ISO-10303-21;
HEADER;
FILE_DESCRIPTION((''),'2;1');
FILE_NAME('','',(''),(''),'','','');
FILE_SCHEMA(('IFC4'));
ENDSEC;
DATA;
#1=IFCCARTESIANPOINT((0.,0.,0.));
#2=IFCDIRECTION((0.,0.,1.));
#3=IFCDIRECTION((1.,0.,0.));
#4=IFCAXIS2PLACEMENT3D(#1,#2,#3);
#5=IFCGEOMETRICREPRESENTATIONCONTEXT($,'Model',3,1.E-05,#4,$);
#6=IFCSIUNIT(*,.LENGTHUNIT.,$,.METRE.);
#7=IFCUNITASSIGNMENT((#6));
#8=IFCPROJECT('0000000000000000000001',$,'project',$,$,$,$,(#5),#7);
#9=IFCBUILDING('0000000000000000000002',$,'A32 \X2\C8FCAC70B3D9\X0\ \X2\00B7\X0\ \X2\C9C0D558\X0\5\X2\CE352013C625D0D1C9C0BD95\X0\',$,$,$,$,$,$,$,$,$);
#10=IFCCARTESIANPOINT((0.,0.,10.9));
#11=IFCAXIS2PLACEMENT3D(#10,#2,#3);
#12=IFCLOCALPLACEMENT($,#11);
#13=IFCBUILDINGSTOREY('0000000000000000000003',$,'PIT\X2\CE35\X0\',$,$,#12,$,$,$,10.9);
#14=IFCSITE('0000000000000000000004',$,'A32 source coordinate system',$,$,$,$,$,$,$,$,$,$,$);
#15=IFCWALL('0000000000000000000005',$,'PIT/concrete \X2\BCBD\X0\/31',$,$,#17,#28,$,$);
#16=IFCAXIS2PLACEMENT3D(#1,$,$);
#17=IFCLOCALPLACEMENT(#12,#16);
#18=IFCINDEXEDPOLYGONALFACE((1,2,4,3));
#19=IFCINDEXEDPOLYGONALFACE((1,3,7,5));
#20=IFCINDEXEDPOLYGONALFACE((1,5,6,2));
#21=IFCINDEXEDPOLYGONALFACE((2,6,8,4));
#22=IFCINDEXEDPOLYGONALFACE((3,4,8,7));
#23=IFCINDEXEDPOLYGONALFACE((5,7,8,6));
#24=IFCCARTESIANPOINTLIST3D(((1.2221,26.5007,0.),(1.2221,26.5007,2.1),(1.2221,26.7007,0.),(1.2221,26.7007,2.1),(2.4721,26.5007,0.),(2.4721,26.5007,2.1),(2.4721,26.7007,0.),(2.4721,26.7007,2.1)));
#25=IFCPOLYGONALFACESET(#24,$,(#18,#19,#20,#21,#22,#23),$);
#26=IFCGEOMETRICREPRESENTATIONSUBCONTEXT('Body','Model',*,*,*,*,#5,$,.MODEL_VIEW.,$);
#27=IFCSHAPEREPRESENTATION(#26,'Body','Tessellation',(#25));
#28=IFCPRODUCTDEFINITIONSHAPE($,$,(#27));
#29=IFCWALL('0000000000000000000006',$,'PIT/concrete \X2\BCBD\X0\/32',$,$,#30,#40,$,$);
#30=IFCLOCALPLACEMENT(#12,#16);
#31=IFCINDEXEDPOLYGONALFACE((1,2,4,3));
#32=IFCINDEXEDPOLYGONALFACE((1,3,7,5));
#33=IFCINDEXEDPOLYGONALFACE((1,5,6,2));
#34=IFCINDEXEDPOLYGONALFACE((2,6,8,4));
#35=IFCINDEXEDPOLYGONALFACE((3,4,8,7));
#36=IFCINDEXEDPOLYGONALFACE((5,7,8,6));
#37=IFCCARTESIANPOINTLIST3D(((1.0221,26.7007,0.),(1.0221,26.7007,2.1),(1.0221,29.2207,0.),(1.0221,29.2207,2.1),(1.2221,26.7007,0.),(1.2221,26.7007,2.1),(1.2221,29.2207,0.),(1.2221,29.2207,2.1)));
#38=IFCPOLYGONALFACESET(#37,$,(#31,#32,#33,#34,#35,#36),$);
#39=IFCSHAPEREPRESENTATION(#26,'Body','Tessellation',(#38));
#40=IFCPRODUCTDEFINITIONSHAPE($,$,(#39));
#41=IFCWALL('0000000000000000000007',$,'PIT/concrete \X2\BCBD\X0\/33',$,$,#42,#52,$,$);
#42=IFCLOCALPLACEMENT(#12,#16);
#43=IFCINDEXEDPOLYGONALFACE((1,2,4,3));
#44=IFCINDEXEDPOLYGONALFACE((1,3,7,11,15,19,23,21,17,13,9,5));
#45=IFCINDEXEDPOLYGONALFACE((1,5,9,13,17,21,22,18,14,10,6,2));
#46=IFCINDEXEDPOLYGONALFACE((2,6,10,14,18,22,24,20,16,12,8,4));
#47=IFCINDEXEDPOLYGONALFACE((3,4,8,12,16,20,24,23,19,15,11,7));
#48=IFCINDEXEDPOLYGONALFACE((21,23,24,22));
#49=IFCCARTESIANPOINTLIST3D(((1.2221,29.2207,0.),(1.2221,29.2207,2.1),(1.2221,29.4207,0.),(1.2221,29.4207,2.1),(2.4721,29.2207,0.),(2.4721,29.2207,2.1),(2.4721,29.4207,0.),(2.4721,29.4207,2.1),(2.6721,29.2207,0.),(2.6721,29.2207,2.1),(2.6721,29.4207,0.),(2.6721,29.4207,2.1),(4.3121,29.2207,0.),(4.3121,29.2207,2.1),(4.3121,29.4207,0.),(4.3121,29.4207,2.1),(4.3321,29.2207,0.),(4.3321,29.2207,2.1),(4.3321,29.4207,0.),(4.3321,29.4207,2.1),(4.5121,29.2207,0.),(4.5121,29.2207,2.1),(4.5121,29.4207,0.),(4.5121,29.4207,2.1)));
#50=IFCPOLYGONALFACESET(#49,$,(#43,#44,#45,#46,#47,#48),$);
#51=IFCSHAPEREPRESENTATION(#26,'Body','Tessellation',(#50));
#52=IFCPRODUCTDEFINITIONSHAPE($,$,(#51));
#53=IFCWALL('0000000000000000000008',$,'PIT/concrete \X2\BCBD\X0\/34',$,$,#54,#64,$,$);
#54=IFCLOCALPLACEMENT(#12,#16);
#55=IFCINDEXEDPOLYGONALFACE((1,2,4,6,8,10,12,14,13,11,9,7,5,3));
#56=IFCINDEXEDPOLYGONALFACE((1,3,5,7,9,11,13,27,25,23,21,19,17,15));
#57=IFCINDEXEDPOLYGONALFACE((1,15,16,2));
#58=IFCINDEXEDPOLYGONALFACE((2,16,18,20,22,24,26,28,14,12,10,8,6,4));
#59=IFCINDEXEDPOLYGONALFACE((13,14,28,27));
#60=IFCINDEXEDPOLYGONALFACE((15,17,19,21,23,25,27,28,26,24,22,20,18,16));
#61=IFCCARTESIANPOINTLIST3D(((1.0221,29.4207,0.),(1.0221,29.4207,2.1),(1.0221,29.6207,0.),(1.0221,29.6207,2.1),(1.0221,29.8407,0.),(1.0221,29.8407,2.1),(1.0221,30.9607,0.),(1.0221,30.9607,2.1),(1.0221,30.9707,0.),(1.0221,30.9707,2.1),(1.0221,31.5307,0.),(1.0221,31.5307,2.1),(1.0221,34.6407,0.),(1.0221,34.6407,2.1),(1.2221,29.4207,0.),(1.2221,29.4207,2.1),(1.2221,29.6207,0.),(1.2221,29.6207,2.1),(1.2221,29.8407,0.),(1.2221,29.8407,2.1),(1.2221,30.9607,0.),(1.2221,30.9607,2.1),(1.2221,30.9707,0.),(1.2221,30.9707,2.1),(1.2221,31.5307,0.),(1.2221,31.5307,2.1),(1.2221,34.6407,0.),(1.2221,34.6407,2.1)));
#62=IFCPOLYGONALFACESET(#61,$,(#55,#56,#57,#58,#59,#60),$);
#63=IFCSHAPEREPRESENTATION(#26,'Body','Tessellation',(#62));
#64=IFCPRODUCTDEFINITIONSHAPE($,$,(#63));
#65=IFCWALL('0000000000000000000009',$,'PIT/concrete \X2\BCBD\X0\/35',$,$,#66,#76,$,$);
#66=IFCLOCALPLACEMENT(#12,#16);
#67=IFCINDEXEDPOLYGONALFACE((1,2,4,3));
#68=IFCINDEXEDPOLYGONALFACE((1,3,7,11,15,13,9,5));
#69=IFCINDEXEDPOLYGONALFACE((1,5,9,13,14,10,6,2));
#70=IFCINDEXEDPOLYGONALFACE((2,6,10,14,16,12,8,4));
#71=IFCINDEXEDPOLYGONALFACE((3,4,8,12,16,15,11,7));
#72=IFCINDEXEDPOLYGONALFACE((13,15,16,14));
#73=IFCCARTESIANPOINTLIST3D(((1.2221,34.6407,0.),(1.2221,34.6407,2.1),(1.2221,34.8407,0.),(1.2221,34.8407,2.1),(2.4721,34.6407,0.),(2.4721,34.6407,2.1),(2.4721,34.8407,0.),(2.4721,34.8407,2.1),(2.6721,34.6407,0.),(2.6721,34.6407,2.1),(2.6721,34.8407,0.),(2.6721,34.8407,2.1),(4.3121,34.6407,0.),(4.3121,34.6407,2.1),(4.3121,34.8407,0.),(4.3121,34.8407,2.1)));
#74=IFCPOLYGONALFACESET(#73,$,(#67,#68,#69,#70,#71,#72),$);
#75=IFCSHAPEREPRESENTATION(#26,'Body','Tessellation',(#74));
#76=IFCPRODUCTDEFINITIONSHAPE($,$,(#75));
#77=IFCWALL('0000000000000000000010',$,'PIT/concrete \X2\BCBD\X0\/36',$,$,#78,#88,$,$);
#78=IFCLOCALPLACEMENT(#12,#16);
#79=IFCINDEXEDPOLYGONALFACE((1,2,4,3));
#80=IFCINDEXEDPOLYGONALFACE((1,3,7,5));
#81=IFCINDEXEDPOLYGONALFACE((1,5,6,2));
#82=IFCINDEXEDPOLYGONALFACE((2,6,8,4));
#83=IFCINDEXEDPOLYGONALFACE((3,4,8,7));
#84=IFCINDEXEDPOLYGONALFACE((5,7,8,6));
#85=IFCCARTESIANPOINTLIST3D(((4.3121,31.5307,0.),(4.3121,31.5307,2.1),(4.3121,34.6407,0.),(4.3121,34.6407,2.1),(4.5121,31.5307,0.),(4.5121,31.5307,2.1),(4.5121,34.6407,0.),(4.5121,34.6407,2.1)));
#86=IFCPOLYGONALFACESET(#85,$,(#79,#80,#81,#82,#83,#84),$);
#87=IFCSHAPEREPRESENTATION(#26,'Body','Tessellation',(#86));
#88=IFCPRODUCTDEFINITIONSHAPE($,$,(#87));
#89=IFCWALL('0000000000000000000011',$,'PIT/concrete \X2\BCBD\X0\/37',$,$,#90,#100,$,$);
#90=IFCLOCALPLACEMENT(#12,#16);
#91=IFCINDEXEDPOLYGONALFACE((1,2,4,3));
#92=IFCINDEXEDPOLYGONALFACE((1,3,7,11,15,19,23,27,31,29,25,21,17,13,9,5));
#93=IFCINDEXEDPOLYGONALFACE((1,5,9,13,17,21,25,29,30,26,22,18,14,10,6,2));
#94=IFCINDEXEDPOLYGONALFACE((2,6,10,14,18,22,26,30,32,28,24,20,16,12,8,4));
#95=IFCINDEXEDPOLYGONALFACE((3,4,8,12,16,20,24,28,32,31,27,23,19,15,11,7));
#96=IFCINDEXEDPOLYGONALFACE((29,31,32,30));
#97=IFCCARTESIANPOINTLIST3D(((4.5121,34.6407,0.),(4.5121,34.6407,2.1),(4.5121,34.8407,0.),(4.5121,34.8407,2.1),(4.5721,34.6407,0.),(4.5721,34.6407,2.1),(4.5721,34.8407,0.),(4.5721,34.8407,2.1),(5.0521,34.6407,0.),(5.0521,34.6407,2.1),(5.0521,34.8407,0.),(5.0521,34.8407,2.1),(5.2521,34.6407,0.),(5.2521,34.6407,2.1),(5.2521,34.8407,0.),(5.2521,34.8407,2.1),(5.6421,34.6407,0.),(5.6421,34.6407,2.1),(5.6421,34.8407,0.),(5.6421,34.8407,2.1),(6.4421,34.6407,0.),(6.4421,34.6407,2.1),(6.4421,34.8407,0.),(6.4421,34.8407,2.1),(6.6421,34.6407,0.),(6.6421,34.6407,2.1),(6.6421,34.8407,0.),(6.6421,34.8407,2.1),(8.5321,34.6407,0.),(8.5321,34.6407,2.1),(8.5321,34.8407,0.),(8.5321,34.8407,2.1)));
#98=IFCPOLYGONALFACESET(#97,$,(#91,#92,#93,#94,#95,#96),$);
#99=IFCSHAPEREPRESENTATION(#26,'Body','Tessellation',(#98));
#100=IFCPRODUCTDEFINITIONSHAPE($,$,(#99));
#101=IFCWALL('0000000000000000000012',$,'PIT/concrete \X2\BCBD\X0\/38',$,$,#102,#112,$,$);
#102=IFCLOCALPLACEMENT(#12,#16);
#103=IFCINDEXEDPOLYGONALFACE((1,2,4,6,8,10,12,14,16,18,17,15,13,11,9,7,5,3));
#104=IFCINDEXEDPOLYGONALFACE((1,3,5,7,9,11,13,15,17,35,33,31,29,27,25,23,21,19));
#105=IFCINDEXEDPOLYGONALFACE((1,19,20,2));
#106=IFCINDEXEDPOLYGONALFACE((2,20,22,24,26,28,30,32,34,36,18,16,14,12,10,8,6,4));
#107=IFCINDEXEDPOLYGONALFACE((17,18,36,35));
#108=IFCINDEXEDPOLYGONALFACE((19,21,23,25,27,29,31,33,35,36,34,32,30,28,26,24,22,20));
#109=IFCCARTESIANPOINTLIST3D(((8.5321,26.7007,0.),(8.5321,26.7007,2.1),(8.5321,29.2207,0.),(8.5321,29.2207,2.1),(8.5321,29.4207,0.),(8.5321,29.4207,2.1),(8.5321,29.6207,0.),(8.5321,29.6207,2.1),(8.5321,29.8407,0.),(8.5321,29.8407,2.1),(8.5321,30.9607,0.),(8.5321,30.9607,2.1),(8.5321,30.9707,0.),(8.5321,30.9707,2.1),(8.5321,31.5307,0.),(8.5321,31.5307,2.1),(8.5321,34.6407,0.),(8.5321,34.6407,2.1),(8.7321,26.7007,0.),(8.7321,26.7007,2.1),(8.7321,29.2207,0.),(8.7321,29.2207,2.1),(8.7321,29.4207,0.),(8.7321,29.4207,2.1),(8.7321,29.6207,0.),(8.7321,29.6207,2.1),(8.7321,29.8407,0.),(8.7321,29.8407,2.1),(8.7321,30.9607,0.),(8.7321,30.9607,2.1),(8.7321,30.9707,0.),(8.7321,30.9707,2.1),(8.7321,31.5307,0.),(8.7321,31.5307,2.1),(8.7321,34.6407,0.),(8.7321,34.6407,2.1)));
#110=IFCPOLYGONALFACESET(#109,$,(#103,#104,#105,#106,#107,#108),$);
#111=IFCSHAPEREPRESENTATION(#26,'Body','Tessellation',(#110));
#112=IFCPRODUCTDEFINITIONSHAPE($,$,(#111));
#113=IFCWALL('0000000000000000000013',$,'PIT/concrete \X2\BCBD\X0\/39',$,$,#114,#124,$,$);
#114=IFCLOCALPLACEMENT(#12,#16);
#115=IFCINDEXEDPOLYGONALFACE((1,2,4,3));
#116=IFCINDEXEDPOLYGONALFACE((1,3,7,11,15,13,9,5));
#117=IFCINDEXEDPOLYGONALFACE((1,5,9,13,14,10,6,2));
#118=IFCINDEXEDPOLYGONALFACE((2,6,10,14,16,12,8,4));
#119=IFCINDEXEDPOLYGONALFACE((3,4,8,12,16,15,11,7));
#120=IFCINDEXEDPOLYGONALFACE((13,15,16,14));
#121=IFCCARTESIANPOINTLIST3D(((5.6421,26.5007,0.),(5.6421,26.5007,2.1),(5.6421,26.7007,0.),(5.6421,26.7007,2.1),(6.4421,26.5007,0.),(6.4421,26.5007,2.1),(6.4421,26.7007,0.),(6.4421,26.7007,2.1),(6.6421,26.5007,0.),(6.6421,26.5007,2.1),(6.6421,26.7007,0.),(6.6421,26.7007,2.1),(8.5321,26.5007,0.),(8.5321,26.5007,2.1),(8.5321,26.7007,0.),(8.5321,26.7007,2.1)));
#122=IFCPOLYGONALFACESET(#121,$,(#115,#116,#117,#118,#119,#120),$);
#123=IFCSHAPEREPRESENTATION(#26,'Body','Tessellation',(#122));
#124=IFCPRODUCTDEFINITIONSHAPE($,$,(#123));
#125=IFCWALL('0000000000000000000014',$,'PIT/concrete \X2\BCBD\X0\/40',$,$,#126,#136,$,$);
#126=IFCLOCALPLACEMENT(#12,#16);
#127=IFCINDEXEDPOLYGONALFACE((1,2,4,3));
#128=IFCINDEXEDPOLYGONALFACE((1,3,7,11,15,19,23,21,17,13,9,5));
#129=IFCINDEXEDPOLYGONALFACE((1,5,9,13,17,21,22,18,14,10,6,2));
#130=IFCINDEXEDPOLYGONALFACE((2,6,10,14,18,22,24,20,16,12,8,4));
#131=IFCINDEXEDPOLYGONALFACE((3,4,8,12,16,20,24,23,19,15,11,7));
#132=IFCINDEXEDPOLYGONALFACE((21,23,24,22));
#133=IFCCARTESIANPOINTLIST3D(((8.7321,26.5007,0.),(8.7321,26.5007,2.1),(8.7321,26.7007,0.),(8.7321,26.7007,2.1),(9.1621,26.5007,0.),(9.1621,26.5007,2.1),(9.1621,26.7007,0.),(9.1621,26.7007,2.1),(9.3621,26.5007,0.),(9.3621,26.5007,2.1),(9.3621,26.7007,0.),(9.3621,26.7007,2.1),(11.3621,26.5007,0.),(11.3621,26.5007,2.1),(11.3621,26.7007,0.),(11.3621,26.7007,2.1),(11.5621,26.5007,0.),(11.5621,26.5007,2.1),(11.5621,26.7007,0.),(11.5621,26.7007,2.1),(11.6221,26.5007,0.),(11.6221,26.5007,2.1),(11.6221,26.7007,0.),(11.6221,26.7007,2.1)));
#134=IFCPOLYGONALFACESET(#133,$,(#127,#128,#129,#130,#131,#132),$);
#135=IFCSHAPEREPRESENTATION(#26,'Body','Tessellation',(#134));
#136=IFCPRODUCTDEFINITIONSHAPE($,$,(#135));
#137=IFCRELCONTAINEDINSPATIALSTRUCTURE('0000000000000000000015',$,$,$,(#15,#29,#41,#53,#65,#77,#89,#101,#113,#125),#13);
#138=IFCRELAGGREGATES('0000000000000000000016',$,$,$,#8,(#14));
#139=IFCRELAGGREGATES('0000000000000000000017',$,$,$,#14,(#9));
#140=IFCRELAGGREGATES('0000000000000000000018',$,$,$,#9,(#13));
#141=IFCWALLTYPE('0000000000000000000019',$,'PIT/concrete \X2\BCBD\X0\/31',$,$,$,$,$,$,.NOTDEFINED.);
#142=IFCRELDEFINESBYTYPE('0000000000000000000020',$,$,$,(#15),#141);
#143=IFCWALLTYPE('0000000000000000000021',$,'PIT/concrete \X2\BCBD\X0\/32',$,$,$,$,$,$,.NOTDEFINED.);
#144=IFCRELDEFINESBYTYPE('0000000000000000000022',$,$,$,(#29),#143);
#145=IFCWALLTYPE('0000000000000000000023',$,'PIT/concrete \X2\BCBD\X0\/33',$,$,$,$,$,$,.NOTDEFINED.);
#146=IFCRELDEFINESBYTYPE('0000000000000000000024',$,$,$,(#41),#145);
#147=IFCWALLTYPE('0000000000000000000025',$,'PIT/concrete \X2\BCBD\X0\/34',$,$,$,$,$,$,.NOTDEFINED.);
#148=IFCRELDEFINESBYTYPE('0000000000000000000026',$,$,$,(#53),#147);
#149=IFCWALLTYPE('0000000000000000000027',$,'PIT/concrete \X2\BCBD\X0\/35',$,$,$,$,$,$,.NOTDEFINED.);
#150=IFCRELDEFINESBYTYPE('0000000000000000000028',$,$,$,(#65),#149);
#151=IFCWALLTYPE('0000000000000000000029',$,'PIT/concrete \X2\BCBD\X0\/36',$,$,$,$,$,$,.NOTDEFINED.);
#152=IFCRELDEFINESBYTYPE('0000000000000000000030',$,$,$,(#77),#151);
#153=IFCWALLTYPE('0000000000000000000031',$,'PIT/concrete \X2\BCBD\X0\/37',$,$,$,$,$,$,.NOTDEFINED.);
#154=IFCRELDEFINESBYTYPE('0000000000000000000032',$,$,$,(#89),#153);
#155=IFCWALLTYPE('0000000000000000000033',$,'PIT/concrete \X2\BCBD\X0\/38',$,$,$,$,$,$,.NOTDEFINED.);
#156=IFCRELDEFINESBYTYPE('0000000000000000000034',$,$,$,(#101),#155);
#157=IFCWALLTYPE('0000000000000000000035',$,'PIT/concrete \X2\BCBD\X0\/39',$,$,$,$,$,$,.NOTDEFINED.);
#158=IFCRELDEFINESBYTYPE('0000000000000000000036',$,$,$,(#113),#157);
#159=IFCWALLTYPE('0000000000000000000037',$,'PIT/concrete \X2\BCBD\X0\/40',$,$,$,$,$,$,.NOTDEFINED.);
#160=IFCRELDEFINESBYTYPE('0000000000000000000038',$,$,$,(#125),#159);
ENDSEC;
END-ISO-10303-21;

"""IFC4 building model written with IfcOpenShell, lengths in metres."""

from ifc_helpers import new_model, si_unit, frame, origin, origin_with_axes, place, context, subcontext, project, spatial, polyline, outline, extrude, source, transform, mapped, type_object, type_shapes, element, save


model = new_model("IFC4")

# Units and contexts
model_context = context("Model", 3, precision=1e-05, world=origin_with_axes())
body_context = subcontext(model_context, "Body", "Model", "MODEL_VIEW")
ifc_project = project(units=[si_unit("LENGTHUNIT", "METRE")], contexts=[model_context])

# Site, building, storey
site = spatial("IfcSite", under=ifc_project, Name="A32 source coordinate system")
building = spatial("IfcBuilding", under=site, Name="A32 주거동 · 지하5층–옥탑지붕")
storey_placement = place(None, frame((0.0, 0.0, 10.9), z_axis=(0.0, 0.0, 1.0), x_axis=(1.0, 0.0, 0.0)))
storey = spatial("IfcBuildingStorey", under=building, at=storey_placement, Name="PIT층", Elevation=10.9)

# Walls
wall_type_1 = type_object("IfcWallType", Name="PIT/concrete 벽/31", PredefinedType="NOTDEFINED")
shared_shape_1 = source(origin(), body_context, "Body", "SweptSolid", [
    extrude(outline(polyline([(2.4721, 26.5007), (1.2221, 26.5007), (1.2221, 26.7007), (2.4721, 26.7007), (2.4721, 26.5007)])), origin(), (0.0, 0.0, 1.0), 2.1),
])
type_shapes(wall_type_1, [shared_shape_1])
wall_1_placement = place(storey_placement, origin_with_axes())
element("IfcWall", 1, at=wall_1_placement, inside=storey, type_object=wall_type_1, Name="PIT/concrete 벽/31", context=body_context, shape_type="MappedRepresentation", body=[
    mapped(shared_shape_1, transform((0.0, 0.0, 0.0), scale=1.0)),
])
wall_type_2 = type_object("IfcWallType", Name="PIT/concrete 벽/32", PredefinedType="NOTDEFINED")
shared_shape_2 = source(origin(), body_context, "Body", "SweptSolid", [
    extrude(outline(polyline([(1.2221, 29.2207), (1.2221, 26.7007), (1.0221, 26.7007), (1.0221, 29.2207), (1.2221, 29.2207)])), origin(), (0.0, 0.0, 1.0), 2.1),
])
type_shapes(wall_type_2, [shared_shape_2])
wall_2_placement = place(storey_placement, origin_with_axes())
element("IfcWall", 2, at=wall_2_placement, inside=storey, type_object=wall_type_2, Name="PIT/concrete 벽/32", context=body_context, shape_type="MappedRepresentation", body=[
    mapped(shared_shape_2, transform((0.0, 0.0, 0.0), scale=1.0)),
])
wall_type_3 = type_object("IfcWallType", Name="PIT/concrete 벽/33", PredefinedType="NOTDEFINED")
shared_shape_3 = source(origin(), body_context, "Body", "SweptSolid", [
    extrude(outline(polyline([(2.6721, 29.4207), (4.3121, 29.4207), (4.3321, 29.4207), (4.5121, 29.4207), (4.5121, 29.2207), (4.3321, 29.2207), (4.3121, 29.2207), (2.6721, 29.2207), (2.4721, 29.2207), (1.2221, 29.2207), (1.2221, 29.4207), (2.4721, 29.4207), (2.6721, 29.4207)])), origin(), (0.0, 0.0, 1.0), 2.1),
])
type_shapes(wall_type_3, [shared_shape_3])
wall_3_placement = place(storey_placement, origin_with_axes())
element("IfcWall", 3, at=wall_3_placement, inside=storey, type_object=wall_type_3, Name="PIT/concrete 벽/33", context=body_context, shape_type="MappedRepresentation", body=[
    mapped(shared_shape_3, transform((0.0, 0.0, 0.0), scale=1.0)),
])
wall_type_4 = type_object("IfcWallType", Name="PIT/concrete 벽/34", PredefinedType="NOTDEFINED")
shared_shape_4 = source(origin(), body_context, "Body", "SweptSolid", [
    extrude(outline(polyline([(1.0221, 29.8407), (1.0221, 30.9607), (1.0221, 30.9707), (1.0221, 31.5307), (1.0221, 34.6407), (1.2221, 34.6407), (1.2221, 31.5307), (1.2221, 30.9707), (1.2221, 30.9607), (1.2221, 29.8407), (1.2221, 29.6207), (1.2221, 29.4207), (1.0221, 29.4207), (1.0221, 29.6207), (1.0221, 29.8407)])), origin(), (0.0, 0.0, 1.0), 2.1),
])
type_shapes(wall_type_4, [shared_shape_4])
wall_4_placement = place(storey_placement, origin_with_axes())
element("IfcWall", 4, at=wall_4_placement, inside=storey, type_object=wall_type_4, Name="PIT/concrete 벽/34", context=body_context, shape_type="MappedRepresentation", body=[
    mapped(shared_shape_4, transform((0.0, 0.0, 0.0), scale=1.0)),
])
wall_type_5 = type_object("IfcWallType", Name="PIT/concrete 벽/35", PredefinedType="NOTDEFINED")
shared_shape_5 = source(origin(), body_context, "Body", "SweptSolid", [
    extrude(outline(polyline([(2.6721, 34.8407), (4.3121, 34.8407), (4.3121, 34.6407), (2.6721, 34.6407), (2.4721, 34.6407), (1.2221, 34.6407), (1.2221, 34.8407), (2.4721, 34.8407), (2.6721, 34.8407)])), origin(), (0.0, 0.0, 1.0), 2.1),
])
type_shapes(wall_type_5, [shared_shape_5])
wall_5_placement = place(storey_placement, origin_with_axes())
element("IfcWall", 5, at=wall_5_placement, inside=storey, type_object=wall_type_5, Name="PIT/concrete 벽/35", context=body_context, shape_type="MappedRepresentation", body=[
    mapped(shared_shape_5, transform((0.0, 0.0, 0.0), scale=1.0)),
])
wall_type_6 = type_object("IfcWallType", Name="PIT/concrete 벽/36", PredefinedType="NOTDEFINED")
shared_shape_6 = source(origin(), body_context, "Body", "SweptSolid", [
    extrude(outline(polyline([(4.3121, 31.5307), (4.3121, 34.6407), (4.5121, 34.6407), (4.5121, 31.5307), (4.3121, 31.5307)])), origin(), (0.0, 0.0, 1.0), 2.1),
])
type_shapes(wall_type_6, [shared_shape_6])
wall_6_placement = place(storey_placement, origin_with_axes())
element("IfcWall", 6, at=wall_6_placement, inside=storey, type_object=wall_type_6, Name="PIT/concrete 벽/36", context=body_context, shape_type="MappedRepresentation", body=[
    mapped(shared_shape_6, transform((0.0, 0.0, 0.0), scale=1.0)),
])
wall_type_7 = type_object("IfcWallType", Name="PIT/concrete 벽/37", PredefinedType="NOTDEFINED")
shared_shape_7 = source(origin(), body_context, "Body", "SweptSolid", [
    extrude(outline(polyline([(5.0521, 34.8407), (5.2521, 34.8407), (5.6421, 34.8407), (6.4421, 34.8407), (6.6421, 34.8407), (8.5321, 34.8407), (8.5321, 34.6407), (6.6421, 34.6407), (6.4421, 34.6407), (5.6421, 34.6407), (5.2521, 34.6407), (5.0521, 34.6407), (4.5721, 34.6407), (4.5121, 34.6407), (4.5121, 34.8407), (4.5721, 34.8407), (5.0521, 34.8407)])), origin(), (0.0, 0.0, 1.0), 2.1),
])
type_shapes(wall_type_7, [shared_shape_7])
wall_7_placement = place(storey_placement, origin_with_axes())
element("IfcWall", 7, at=wall_7_placement, inside=storey, type_object=wall_type_7, Name="PIT/concrete 벽/37", context=body_context, shape_type="MappedRepresentation", body=[
    mapped(shared_shape_7, transform((0.0, 0.0, 0.0), scale=1.0)),
])
wall_type_8 = type_object("IfcWallType", Name="PIT/concrete 벽/38", PredefinedType="NOTDEFINED")
shared_shape_8 = source(origin(), body_context, "Body", "SweptSolid", [
    extrude(outline(polyline([(8.7321, 30.9707), (8.7321, 30.9607), (8.7321, 29.8407), (8.7321, 29.6207), (8.7321, 29.4207), (8.7321, 29.2207), (8.7321, 26.7007), (8.5321, 26.7007), (8.5321, 29.2207), (8.5321, 29.4207), (8.5321, 29.6207), (8.5321, 29.8407), (8.5321, 30.9607), (8.5321, 30.9707), (8.5321, 31.5307), (8.5321, 34.6407), (8.7321, 34.6407), (8.7321, 31.5307), (8.7321, 30.9707)])), origin(), (0.0, 0.0, 1.0), 2.1),
])
type_shapes(wall_type_8, [shared_shape_8])
wall_8_placement = place(storey_placement, origin_with_axes())
element("IfcWall", 8, at=wall_8_placement, inside=storey, type_object=wall_type_8, Name="PIT/concrete 벽/38", context=body_context, shape_type="MappedRepresentation", body=[
    mapped(shared_shape_8, transform((0.0, 0.0, 0.0), scale=1.0)),
])
wall_type_9 = type_object("IfcWallType", Name="PIT/concrete 벽/39", PredefinedType="NOTDEFINED")
shared_shape_9 = source(origin(), body_context, "Body", "SweptSolid", [
    extrude(outline(polyline([(6.4421, 26.5007), (5.6421, 26.5007), (5.6421, 26.7007), (6.4421, 26.7007), (6.6421, 26.7007), (8.5321, 26.7007), (8.5321, 26.5007), (6.6421, 26.5007), (6.4421, 26.5007)])), origin(), (0.0, 0.0, 1.0), 2.1),
])
type_shapes(wall_type_9, [shared_shape_9])
wall_9_placement = place(storey_placement, origin_with_axes())
element("IfcWall", 9, at=wall_9_placement, inside=storey, type_object=wall_type_9, Name="PIT/concrete 벽/39", context=body_context, shape_type="MappedRepresentation", body=[
    mapped(shared_shape_9, transform((0.0, 0.0, 0.0), scale=1.0)),
])
wall_type_10 = type_object("IfcWallType", Name="PIT/concrete 벽/40", PredefinedType="NOTDEFINED")
shared_shape_10 = source(origin(), body_context, "Body", "SweptSolid", [
    extrude(outline(polyline([(11.3621, 26.7007), (11.5621, 26.7007), (11.6221, 26.7007), (11.6221, 26.5007), (11.5621, 26.5007), (11.3621, 26.5007), (9.3621, 26.5007), (9.1621, 26.5007), (8.7321, 26.5007), (8.7321, 26.7007), (9.1621, 26.7007), (9.3621, 26.7007), (11.3621, 26.7007)])), origin(), (0.0, 0.0, 1.0), 2.1),
])
type_shapes(wall_type_10, [shared_shape_10])
wall_10_placement = place(storey_placement, origin_with_axes())
element("IfcWall", 10, at=wall_10_placement, inside=storey, type_object=wall_type_10, Name="PIT/concrete 벽/40", context=body_context, shape_type="MappedRepresentation", body=[
    mapped(shared_shape_10, transform((0.0, 0.0, 0.0), scale=1.0)),
])

save(model, "model.ifc")
